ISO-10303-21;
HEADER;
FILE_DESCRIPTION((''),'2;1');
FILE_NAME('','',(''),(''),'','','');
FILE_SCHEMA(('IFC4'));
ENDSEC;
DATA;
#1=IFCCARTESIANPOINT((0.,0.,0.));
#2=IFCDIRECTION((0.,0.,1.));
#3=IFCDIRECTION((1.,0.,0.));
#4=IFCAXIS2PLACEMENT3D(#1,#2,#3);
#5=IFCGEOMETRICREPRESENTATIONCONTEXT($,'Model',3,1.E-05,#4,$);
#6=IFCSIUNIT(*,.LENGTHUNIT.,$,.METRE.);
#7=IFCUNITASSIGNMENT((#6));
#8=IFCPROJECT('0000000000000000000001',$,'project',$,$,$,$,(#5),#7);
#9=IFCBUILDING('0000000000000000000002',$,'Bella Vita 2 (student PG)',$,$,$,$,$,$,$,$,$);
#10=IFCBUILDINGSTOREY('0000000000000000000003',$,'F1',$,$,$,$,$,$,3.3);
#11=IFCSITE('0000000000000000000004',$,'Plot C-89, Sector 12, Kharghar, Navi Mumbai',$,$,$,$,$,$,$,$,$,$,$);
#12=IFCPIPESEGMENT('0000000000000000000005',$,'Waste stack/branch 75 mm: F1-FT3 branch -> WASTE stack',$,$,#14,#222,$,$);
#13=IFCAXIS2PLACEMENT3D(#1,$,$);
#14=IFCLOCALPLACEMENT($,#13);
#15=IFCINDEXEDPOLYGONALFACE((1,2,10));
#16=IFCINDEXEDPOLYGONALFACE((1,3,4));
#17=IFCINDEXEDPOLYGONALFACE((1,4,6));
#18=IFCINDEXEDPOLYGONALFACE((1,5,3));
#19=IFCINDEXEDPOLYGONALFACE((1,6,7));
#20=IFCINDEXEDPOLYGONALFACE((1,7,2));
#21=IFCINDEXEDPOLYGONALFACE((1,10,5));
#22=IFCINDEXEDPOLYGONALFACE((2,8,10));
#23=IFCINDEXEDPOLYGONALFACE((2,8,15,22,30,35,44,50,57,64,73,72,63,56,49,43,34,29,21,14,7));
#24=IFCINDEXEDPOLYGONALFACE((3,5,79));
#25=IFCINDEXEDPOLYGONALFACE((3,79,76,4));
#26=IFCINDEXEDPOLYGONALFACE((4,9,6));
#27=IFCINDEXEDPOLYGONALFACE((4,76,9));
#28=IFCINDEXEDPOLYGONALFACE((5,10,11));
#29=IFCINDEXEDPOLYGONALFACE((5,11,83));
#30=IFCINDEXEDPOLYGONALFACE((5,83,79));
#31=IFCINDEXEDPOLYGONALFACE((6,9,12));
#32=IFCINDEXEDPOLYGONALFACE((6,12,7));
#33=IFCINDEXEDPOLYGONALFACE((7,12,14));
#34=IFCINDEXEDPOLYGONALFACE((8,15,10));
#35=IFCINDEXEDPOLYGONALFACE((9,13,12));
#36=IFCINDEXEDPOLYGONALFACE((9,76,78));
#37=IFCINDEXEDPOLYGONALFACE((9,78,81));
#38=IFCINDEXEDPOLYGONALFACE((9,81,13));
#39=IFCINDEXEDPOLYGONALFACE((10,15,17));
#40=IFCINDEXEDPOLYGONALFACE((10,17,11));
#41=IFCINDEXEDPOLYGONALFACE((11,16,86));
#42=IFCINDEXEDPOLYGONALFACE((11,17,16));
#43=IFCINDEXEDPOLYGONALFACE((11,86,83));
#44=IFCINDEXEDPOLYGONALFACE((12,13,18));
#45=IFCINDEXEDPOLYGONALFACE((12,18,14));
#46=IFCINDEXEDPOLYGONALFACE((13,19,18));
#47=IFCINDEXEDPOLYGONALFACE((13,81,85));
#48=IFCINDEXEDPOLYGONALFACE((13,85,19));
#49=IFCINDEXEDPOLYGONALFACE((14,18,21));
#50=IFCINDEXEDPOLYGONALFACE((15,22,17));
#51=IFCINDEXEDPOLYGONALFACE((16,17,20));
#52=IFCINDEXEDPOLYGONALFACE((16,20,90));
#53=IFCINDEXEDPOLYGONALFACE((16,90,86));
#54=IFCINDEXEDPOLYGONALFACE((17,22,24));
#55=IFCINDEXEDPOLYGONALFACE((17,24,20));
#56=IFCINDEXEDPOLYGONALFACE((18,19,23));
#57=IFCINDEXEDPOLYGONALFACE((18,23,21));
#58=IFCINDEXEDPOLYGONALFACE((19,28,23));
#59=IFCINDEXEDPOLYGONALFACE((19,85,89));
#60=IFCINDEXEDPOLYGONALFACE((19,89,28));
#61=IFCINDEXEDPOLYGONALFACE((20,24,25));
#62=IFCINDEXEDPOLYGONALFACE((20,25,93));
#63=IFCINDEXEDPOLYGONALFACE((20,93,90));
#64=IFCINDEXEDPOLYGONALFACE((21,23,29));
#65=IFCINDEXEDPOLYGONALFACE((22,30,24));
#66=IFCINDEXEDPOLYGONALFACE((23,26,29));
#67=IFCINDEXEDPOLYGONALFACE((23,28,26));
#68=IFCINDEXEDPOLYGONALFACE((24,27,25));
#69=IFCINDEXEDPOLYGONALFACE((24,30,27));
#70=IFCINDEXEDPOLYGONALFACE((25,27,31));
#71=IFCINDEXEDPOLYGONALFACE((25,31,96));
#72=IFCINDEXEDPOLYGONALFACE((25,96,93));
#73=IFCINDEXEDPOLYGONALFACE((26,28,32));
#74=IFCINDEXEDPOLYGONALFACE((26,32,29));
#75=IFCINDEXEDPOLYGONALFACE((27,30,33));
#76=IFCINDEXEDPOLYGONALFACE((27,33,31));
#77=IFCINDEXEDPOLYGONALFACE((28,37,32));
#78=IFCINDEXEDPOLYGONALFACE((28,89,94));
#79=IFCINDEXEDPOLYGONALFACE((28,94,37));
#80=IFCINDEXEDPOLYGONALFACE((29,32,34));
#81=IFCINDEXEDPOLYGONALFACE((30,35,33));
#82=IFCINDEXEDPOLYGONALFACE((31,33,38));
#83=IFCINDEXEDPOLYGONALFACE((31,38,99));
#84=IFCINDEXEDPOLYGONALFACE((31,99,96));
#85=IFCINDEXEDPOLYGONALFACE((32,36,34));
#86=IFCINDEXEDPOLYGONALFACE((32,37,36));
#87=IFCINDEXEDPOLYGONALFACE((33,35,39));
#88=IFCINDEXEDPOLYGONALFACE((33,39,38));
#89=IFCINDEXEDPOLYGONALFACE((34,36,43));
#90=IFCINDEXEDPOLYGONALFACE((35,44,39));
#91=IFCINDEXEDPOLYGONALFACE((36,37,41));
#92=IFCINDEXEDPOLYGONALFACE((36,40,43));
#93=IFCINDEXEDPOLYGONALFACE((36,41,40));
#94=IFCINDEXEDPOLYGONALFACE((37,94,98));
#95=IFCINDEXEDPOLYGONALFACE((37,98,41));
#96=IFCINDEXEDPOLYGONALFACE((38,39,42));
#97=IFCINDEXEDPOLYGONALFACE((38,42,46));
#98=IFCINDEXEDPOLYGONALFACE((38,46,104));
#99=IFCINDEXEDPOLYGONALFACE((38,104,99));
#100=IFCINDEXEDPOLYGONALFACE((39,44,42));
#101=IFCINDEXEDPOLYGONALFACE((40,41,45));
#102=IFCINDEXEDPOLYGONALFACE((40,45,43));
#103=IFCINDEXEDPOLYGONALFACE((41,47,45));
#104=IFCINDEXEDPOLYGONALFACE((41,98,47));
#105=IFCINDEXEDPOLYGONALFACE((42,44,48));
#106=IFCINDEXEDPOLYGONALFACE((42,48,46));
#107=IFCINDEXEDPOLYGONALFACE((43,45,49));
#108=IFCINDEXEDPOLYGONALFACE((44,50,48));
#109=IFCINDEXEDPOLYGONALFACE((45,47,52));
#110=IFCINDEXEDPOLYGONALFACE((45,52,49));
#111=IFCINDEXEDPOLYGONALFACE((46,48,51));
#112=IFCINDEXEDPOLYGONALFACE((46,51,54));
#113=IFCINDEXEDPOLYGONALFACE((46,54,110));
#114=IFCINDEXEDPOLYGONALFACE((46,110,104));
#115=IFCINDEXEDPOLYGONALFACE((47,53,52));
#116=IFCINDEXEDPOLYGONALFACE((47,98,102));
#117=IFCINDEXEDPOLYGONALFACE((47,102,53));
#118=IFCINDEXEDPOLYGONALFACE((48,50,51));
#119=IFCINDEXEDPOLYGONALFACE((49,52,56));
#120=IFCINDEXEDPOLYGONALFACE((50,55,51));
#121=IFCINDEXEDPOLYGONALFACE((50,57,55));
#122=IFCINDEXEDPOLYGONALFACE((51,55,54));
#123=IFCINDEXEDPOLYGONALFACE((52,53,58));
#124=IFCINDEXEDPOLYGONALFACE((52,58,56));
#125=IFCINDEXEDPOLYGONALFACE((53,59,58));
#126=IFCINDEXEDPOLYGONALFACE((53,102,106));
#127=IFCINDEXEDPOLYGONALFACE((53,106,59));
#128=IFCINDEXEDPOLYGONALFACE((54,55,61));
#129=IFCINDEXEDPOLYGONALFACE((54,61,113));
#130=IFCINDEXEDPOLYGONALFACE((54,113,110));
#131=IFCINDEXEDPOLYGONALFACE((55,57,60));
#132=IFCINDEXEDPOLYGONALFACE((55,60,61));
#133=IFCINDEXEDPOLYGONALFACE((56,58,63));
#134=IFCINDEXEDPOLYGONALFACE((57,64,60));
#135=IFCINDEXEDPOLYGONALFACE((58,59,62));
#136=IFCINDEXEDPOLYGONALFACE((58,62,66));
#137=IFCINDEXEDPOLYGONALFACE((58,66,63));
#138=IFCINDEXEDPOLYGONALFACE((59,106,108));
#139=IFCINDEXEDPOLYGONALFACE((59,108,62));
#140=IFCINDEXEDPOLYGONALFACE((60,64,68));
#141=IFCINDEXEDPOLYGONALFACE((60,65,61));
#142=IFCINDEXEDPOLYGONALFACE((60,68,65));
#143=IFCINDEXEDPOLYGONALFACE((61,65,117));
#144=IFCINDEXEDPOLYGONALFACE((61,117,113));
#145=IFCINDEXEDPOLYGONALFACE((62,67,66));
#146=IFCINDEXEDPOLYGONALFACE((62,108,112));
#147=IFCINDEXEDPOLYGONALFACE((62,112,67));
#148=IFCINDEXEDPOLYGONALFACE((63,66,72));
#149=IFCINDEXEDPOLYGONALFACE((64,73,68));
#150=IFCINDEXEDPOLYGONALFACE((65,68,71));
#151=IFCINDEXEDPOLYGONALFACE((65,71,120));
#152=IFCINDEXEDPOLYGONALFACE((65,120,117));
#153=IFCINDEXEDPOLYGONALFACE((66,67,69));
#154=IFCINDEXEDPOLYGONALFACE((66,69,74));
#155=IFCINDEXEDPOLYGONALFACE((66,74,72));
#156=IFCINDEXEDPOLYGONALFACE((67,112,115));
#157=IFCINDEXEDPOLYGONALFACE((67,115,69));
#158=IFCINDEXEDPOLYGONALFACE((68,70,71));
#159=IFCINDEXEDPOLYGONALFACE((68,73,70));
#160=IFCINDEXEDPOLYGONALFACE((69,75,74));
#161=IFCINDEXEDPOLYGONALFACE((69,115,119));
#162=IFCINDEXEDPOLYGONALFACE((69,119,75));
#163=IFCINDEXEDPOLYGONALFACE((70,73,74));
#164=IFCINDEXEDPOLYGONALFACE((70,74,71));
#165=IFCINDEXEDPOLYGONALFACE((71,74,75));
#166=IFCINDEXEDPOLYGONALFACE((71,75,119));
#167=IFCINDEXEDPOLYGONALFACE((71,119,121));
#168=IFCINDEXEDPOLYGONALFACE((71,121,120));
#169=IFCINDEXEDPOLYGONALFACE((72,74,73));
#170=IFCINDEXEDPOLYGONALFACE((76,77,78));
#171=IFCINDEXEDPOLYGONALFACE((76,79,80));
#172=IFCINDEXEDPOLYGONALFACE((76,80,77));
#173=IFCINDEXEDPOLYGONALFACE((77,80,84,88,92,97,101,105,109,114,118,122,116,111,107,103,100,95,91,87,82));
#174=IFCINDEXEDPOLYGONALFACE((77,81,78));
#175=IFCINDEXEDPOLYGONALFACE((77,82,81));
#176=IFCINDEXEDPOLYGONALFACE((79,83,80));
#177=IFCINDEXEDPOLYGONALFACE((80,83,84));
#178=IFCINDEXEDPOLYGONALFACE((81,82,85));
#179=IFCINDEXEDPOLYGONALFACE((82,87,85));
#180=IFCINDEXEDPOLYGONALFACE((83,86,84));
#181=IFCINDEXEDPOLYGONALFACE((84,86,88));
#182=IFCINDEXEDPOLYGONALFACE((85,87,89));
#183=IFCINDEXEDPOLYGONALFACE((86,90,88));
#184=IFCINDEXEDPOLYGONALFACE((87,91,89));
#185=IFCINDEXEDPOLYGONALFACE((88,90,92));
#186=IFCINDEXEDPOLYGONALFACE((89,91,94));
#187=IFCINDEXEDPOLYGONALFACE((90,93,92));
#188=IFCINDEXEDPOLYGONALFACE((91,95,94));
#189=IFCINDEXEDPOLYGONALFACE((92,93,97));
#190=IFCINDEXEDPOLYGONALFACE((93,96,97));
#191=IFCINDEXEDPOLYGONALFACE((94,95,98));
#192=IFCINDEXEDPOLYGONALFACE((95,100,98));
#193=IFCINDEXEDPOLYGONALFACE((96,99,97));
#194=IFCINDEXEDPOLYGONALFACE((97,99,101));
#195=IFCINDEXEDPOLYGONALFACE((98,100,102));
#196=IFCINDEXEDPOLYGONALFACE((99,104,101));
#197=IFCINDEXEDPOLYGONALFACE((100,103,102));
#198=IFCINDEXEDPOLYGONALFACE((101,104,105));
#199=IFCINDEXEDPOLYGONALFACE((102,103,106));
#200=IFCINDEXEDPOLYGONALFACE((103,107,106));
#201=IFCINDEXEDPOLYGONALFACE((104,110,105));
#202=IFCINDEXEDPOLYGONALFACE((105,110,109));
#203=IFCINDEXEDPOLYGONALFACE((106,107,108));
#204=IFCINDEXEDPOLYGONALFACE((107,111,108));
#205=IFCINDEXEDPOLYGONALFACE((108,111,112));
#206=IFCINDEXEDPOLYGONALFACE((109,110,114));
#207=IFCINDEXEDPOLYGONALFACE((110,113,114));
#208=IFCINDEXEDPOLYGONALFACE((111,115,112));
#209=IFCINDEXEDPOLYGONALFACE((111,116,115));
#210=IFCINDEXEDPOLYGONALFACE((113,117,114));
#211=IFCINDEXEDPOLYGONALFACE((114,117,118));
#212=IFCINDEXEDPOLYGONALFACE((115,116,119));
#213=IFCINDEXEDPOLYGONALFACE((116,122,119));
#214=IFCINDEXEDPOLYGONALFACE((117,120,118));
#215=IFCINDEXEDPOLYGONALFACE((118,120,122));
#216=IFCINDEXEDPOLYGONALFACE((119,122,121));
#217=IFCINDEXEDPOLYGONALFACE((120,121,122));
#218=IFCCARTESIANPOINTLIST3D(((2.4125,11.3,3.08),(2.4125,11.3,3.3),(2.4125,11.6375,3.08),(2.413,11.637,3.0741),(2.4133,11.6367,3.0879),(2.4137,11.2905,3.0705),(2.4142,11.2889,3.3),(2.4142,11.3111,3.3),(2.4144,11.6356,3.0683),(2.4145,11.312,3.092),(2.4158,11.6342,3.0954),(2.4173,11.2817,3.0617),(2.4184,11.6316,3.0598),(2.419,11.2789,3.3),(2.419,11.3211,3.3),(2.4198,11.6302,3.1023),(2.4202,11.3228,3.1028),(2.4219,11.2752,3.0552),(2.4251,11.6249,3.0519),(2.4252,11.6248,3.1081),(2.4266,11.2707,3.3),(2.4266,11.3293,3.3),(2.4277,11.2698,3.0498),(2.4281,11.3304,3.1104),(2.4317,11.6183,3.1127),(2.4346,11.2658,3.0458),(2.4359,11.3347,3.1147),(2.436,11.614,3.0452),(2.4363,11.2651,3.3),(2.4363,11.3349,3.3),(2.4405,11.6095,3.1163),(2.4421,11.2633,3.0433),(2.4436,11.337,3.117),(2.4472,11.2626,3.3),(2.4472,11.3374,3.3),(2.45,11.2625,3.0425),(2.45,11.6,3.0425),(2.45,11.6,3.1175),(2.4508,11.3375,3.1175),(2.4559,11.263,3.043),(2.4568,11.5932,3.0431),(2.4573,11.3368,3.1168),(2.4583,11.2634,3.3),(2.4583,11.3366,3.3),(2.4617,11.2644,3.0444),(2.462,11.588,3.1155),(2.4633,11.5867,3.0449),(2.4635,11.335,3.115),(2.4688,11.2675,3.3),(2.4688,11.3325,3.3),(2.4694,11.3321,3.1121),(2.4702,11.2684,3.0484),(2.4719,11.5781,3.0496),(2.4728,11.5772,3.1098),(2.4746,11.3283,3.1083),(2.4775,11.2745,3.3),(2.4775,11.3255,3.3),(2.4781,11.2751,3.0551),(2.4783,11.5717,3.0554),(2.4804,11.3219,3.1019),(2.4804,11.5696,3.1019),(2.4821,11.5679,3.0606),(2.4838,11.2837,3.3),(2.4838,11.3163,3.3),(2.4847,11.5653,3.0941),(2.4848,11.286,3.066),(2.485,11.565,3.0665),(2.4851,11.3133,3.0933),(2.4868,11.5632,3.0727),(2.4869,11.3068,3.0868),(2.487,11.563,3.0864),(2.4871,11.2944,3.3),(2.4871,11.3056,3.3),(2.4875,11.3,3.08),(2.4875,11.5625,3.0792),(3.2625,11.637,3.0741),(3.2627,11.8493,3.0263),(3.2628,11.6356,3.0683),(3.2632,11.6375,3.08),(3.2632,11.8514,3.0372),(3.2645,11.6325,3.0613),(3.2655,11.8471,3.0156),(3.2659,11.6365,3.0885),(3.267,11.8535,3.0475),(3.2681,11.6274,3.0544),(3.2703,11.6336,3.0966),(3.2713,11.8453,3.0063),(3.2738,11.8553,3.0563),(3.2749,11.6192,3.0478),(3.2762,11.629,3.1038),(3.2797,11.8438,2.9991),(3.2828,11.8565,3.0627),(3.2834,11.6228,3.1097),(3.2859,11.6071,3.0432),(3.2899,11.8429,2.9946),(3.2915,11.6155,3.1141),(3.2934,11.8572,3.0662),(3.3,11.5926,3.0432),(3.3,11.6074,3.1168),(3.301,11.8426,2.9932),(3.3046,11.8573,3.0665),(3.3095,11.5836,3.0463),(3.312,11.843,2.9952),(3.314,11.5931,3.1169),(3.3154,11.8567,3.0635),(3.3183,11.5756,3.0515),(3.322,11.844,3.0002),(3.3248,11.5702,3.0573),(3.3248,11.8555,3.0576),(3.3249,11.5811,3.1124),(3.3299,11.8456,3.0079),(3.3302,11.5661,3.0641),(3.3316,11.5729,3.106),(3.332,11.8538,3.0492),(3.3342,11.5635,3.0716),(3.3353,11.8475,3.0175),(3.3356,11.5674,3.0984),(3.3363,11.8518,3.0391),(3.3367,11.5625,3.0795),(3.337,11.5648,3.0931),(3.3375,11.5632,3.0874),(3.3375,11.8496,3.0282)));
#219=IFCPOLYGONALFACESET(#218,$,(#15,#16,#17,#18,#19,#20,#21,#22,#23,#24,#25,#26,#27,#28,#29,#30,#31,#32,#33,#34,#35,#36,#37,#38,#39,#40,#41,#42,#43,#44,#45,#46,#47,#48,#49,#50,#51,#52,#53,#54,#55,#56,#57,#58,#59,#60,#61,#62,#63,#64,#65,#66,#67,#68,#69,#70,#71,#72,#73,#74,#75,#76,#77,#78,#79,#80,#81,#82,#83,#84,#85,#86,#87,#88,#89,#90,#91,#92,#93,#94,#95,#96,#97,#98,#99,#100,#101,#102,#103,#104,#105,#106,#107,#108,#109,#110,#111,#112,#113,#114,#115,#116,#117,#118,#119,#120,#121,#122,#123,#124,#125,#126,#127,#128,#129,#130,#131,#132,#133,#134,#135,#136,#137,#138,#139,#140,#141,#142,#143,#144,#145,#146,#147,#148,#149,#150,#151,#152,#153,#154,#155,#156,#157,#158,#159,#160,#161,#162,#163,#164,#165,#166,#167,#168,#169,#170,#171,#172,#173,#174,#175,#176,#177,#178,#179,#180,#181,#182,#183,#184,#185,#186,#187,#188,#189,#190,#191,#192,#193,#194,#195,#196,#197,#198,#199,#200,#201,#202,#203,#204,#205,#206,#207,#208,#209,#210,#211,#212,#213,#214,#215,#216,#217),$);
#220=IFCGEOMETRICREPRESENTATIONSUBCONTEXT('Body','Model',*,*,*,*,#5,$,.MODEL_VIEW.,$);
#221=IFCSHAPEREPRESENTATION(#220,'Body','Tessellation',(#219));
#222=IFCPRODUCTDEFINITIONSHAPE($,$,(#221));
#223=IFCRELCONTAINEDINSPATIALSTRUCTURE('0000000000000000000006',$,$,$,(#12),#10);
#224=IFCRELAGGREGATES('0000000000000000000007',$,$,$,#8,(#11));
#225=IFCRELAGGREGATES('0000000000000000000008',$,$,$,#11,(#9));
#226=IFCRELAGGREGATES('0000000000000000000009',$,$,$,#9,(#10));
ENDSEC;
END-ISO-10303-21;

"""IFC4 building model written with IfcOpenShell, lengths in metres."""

from ifc_helpers import new_model, entity, si_unit, origin, origin_with_axes, place, context, subcontext, project, spatial, element, save


model = new_model("IFC4")

# Units and contexts
model_context = context("Model", 3, precision=1e-05, world=origin_with_axes())
body_context = subcontext(model_context, "Body", "Model", "MODEL_VIEW")
ifc_project = project(units=[si_unit("LENGTHUNIT", "METRE")], contexts=[model_context])

# Site, building, storey
site = spatial("IfcSite", under=ifc_project, Name="Plot C-89, Sector 12, Kharghar, Navi Mumbai")
building = spatial("IfcBuilding", under=site, Name="Bella Vita 2 (student PG)")
storey = spatial("IfcBuildingStorey", under=building, Name="F1", Elevation=3.3)

# Pipe segment
pipe_segment_1_placement = place(None, origin())
element("IfcPipeSegment", 1, at=pipe_segment_1_placement, inside=storey, Name="Waste stack/branch 75 mm: F1-FT3 branch -> WASTE stack", context=body_context, shape_type="AdvancedSweptSolid", body=[
    entity("IfcSweptDiskSolid", entity("IfcPolyline", [entity("IfcCartesianPoint", [2.45, 11.3, 3.3]), entity("IfcCartesianPoint", [2.45, 11.3, 3.08]), entity("IfcCartesianPoint", [2.45, 11.6, 3.08]), entity("IfcCartesianPoint", [3.3, 11.6, 3.08]), entity("IfcCartesianPoint", [3.3, 11.85, 3.03])]), 0.0375),
])

save(model, "model.ifc")
